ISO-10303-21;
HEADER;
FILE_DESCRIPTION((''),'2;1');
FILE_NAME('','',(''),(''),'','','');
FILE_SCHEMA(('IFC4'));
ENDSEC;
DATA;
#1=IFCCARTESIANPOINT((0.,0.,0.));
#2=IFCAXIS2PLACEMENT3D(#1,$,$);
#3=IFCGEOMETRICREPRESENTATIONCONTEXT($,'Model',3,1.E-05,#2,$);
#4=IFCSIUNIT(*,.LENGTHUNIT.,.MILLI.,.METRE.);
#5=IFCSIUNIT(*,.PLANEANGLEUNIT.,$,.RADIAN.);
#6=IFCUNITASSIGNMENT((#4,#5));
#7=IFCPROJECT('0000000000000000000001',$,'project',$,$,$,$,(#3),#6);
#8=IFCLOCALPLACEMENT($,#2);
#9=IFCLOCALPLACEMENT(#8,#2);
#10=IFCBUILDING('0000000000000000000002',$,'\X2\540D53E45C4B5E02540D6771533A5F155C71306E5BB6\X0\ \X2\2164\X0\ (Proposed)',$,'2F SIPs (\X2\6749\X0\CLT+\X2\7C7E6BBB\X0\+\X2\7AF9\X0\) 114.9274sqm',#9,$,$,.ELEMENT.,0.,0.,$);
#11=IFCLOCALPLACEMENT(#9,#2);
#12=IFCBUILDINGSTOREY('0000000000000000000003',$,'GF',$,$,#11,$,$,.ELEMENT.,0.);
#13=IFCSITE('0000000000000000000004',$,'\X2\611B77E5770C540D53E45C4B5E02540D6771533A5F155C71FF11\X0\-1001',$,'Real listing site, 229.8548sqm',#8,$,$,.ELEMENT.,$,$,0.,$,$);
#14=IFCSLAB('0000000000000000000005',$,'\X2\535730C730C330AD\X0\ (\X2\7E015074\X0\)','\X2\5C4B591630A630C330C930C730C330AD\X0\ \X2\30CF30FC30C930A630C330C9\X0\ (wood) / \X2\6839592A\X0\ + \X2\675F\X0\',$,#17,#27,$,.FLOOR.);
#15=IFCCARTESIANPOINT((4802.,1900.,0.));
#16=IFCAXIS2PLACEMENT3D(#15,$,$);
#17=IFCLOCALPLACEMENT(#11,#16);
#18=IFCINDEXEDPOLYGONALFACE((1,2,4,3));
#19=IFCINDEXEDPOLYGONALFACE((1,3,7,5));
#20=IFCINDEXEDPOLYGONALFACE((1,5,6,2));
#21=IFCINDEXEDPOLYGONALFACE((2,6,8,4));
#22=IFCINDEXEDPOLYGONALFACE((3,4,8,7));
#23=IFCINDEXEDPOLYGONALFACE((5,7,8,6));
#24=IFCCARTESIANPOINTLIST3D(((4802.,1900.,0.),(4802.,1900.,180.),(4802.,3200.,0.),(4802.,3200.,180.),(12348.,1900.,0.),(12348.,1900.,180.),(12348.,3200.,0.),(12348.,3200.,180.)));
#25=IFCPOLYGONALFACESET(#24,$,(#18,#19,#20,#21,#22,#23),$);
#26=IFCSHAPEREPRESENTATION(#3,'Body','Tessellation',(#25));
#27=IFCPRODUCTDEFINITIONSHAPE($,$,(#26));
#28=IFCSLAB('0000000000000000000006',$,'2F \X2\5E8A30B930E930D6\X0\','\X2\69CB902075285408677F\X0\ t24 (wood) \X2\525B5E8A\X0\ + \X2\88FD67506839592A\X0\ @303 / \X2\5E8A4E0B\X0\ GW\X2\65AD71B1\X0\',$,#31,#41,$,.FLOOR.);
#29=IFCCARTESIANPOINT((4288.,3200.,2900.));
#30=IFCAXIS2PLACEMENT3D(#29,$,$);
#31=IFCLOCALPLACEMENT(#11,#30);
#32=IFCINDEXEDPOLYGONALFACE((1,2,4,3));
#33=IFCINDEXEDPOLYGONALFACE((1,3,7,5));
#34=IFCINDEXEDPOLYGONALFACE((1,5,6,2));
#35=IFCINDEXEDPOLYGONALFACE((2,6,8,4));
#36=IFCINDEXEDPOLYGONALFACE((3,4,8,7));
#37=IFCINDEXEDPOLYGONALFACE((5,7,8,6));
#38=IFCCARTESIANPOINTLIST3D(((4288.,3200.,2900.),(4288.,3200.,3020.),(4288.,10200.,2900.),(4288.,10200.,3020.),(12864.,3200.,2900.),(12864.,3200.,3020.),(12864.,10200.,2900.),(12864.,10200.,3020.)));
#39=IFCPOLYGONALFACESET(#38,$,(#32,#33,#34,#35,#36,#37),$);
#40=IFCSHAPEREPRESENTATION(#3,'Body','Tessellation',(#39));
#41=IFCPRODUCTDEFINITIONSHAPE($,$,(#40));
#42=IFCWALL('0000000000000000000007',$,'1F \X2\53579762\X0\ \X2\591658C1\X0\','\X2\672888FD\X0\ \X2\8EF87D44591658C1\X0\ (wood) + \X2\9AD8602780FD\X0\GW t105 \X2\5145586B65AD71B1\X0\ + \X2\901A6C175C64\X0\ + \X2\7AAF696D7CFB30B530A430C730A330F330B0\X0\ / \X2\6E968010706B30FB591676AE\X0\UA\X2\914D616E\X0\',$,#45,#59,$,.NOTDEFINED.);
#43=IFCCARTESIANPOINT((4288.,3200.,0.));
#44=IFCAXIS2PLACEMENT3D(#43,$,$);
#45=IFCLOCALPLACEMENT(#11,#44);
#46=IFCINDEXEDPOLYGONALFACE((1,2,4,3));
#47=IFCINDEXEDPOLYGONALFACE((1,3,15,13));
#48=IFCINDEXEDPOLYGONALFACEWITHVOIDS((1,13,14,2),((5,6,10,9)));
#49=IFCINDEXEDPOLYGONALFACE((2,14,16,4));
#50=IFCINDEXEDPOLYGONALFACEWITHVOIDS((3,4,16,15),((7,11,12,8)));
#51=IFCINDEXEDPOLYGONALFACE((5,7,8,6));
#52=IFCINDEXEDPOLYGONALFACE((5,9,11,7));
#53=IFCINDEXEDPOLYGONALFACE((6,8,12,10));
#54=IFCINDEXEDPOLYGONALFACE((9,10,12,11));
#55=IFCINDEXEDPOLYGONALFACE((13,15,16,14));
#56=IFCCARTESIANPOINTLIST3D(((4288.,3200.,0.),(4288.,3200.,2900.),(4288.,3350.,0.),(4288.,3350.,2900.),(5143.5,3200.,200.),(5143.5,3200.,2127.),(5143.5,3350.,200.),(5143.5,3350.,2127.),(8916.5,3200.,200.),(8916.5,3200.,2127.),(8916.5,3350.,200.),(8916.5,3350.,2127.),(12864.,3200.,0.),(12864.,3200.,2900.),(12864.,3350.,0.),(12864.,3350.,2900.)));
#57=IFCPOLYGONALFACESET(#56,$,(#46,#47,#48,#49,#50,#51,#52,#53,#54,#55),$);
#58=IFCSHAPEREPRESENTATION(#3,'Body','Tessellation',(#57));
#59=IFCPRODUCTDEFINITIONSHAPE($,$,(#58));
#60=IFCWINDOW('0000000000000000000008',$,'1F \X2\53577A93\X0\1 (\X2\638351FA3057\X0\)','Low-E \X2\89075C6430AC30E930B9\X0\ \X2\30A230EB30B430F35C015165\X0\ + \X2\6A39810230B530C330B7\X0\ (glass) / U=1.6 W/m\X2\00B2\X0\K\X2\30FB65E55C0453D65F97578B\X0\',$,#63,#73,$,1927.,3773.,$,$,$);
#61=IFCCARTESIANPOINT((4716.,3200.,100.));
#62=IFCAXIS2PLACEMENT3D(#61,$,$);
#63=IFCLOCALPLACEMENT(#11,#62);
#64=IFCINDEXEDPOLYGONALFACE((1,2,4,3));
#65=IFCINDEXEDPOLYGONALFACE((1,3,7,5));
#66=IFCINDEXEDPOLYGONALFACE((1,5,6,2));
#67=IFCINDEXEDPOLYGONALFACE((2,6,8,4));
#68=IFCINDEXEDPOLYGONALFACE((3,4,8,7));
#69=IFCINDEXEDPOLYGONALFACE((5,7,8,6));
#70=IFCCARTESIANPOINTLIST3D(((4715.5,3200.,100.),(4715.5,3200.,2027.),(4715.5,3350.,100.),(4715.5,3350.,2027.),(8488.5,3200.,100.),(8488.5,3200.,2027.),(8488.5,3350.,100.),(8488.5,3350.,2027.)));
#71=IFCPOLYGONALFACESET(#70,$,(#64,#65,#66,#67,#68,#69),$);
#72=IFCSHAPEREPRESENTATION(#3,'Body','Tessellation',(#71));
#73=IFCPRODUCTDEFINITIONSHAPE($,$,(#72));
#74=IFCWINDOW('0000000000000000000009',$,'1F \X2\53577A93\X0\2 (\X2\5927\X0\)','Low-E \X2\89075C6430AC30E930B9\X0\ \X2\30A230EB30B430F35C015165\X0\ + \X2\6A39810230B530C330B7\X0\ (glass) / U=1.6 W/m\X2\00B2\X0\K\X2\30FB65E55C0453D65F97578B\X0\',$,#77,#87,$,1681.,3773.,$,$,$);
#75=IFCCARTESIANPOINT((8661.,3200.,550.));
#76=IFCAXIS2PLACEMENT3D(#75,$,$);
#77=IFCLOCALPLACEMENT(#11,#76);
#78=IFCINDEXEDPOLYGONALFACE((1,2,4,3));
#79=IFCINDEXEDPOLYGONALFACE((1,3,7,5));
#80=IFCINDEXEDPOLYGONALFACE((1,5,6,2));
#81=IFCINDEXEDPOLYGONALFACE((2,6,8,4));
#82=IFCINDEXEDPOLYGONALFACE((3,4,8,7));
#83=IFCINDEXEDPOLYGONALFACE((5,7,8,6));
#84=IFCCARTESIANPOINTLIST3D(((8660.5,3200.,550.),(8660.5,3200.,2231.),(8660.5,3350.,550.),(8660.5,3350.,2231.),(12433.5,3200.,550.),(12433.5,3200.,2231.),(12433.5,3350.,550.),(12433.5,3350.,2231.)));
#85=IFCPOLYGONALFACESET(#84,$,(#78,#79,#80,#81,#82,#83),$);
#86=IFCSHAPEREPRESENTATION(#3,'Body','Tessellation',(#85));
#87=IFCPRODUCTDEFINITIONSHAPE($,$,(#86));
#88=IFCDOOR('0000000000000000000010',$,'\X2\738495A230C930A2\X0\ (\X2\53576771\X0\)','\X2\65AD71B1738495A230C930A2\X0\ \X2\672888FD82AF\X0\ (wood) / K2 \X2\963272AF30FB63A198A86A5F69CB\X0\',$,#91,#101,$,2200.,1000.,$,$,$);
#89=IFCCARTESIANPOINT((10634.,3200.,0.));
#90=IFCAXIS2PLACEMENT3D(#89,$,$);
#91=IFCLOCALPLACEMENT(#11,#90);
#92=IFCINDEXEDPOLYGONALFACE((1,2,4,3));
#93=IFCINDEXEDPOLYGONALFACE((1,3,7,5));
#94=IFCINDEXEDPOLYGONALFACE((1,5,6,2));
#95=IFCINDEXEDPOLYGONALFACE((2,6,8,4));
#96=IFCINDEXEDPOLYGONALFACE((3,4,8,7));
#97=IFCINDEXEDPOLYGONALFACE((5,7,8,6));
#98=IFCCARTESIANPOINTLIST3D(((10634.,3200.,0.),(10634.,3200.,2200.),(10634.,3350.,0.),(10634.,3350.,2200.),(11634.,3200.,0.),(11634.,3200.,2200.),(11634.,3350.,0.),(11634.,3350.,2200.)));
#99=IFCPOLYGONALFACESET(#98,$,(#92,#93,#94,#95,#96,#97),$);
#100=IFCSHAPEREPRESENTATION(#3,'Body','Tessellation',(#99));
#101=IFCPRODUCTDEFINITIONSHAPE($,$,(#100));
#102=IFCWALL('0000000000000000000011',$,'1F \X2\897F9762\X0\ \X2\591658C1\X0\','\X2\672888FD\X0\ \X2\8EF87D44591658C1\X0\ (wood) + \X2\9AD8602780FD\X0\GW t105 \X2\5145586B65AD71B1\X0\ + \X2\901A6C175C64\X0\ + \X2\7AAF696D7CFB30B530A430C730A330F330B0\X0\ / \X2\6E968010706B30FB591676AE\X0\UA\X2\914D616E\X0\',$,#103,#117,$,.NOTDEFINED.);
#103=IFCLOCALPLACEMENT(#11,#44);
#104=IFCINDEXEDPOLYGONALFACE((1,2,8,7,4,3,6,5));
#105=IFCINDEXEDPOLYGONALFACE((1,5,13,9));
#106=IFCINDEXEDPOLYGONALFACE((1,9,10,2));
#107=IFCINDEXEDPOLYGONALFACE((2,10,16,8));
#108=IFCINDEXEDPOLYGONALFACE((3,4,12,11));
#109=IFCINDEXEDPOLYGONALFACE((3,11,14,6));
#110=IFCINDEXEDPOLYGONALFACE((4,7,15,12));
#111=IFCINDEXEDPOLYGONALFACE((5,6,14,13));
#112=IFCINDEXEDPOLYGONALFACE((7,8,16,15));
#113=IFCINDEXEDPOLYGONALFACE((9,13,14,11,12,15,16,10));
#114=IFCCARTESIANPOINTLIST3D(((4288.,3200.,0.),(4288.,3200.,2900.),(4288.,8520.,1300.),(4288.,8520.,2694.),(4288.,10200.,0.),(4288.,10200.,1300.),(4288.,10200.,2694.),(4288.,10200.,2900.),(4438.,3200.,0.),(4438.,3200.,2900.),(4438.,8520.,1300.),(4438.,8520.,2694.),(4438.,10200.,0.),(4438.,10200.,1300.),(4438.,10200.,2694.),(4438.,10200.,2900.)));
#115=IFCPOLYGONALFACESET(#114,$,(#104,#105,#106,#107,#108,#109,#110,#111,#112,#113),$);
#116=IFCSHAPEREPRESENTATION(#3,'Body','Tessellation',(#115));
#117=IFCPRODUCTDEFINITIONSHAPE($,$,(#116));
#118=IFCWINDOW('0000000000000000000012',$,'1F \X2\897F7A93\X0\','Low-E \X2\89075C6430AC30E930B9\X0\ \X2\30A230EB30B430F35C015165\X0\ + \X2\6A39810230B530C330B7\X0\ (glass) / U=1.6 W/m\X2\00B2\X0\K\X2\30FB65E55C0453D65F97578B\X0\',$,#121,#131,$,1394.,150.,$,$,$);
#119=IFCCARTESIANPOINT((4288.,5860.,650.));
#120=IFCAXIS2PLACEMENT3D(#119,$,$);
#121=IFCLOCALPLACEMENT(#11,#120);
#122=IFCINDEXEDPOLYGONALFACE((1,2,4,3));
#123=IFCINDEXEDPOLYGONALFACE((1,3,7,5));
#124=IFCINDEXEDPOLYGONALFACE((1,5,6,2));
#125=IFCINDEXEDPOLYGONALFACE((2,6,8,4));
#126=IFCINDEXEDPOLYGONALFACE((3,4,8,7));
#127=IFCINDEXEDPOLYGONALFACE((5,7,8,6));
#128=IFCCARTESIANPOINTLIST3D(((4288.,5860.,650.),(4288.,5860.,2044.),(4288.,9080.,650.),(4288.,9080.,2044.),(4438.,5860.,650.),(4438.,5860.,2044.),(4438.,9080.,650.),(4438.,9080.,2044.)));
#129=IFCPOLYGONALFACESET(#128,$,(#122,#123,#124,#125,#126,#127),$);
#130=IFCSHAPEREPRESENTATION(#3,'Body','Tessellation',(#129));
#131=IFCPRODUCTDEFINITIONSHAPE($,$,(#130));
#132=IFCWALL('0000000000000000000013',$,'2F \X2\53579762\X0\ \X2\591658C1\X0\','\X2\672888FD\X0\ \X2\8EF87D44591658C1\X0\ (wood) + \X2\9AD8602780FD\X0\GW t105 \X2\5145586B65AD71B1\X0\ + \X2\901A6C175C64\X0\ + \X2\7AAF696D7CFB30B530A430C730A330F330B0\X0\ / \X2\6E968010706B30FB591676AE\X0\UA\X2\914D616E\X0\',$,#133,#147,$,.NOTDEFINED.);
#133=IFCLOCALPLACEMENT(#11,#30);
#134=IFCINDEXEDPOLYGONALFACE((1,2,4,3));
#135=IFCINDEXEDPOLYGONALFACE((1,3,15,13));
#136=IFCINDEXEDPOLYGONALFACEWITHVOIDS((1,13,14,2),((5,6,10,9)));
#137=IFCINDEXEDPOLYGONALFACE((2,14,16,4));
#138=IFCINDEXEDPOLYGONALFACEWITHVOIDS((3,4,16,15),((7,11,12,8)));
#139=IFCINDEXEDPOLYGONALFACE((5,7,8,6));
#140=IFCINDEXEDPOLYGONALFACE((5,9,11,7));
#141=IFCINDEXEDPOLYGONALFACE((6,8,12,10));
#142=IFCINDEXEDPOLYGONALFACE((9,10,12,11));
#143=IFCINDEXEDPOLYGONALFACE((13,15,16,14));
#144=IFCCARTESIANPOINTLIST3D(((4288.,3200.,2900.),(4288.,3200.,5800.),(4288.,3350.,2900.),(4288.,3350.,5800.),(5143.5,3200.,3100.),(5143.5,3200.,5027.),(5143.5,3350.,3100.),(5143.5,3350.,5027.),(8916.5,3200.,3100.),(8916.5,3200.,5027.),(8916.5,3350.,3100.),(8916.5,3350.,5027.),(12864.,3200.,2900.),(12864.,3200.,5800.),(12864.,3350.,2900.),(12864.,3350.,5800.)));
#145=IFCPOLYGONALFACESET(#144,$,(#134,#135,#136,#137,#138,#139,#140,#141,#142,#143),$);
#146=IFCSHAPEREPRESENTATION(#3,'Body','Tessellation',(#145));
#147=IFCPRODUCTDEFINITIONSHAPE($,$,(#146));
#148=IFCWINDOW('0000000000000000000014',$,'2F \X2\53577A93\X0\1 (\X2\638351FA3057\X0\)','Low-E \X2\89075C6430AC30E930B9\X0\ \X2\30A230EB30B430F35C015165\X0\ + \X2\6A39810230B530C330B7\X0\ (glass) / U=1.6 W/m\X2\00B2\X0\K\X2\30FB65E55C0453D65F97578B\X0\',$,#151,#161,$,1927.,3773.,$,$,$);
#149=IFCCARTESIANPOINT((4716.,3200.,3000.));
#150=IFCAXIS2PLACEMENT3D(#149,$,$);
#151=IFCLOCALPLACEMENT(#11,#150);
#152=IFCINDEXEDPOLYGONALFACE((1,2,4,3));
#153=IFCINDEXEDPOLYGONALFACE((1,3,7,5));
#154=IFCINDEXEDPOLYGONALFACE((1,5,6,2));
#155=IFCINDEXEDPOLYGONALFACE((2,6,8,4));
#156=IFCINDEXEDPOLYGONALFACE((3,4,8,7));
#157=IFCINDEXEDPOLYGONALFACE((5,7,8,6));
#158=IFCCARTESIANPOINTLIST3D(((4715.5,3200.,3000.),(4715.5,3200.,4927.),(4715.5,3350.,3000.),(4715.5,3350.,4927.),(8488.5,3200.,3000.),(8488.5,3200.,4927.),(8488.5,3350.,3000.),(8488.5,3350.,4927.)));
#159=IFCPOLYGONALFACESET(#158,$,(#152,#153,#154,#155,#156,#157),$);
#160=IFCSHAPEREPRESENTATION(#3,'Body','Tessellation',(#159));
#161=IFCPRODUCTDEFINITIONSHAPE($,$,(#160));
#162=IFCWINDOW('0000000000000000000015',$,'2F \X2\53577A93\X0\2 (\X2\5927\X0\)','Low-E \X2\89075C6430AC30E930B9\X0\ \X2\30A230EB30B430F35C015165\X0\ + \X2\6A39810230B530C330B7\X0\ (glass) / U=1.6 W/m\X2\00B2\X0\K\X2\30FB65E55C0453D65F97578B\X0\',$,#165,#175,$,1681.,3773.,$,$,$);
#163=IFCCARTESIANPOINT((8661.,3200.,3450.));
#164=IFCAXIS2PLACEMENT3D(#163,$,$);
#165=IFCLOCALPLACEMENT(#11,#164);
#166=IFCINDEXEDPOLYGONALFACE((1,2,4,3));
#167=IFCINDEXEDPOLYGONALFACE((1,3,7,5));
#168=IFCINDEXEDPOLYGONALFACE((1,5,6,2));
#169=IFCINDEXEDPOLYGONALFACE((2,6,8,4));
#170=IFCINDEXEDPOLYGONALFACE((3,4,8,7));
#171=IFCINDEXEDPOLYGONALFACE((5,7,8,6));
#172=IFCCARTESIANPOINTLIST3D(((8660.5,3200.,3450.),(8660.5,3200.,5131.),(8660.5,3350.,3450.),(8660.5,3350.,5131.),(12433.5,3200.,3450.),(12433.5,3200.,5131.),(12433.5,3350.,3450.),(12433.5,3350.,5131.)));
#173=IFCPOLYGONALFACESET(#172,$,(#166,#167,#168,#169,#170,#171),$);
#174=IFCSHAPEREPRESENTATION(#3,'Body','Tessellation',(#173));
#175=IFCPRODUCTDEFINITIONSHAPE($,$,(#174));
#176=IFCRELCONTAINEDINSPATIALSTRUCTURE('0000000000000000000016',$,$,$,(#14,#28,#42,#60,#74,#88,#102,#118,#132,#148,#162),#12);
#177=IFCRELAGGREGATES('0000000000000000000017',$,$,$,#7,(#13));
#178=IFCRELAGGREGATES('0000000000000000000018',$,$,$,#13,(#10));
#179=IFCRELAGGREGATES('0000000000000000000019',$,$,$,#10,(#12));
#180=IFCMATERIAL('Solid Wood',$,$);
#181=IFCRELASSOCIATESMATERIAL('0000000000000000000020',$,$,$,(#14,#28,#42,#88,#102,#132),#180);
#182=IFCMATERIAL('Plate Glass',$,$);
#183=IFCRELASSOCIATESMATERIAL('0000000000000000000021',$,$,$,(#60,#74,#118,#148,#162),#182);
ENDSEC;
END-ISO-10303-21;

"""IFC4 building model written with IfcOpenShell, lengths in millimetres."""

from ifc_helpers import new_model, si_unit, frame, frame_2d, origin, place, context, project, spatial, rectangle, extrude, material, element, fill, save


model = new_model("IFC4")

# Units and contexts
model_context = context("Model", 3, precision=1e-05, world=origin())
ifc_project = project(units=[si_unit("LENGTHUNIT", "METRE", prefix="MILLI"), si_unit("PLANEANGLEUNIT", "RADIAN")], contexts=[model_context])

# Site, building, storey
site_placement = place(None, origin())
site = spatial("IfcSite", under=ifc_project, at=site_placement, Name="愛知県名古屋市名東区引山１-1001", ObjectType="Real listing site, 229.8548sqm", CompositionType="ELEMENT", RefElevation=0.0)
building_placement = place(site_placement, origin())
building = spatial("IfcBuilding", under=site, at=building_placement, Name="名古屋市名東区引山の家 Ⅴ (Proposed)", ObjectType="2F SIPs (杉CLT+籾殻+竹) 114.9274sqm", CompositionType="ELEMENT", ElevationOfRefHeight=0.0, ElevationOfTerrain=0.0)
storey_placement = place(building_placement, origin())
storey = spatial("IfcBuildingStorey", under=building, at=storey_placement, Name="GF", CompositionType="ELEMENT", Elevation=0.0)

# Slabs
ifc_material_1 = material(Name="Solid Wood")
slab_1_placement = place(storey_placement, frame((4802.0, 1900.0, 0.0)))
element("IfcSlab", 1, at=slab_1_placement, inside=storey, material=ifc_material_1, Name="南デッキ (縁側)", Description="屋外ウッドデッキ ハードウッド (wood) / 根太 + 束", PredefinedType="FLOOR", context=model_context, shape_type="SweptSolid", body=[
    extrude(rectangle(XDim=7546.0, YDim=1300.0, at=frame_2d((3773.0, 650.0))), frame((4802.0, 1900.0, 0.0)), (0.0, 0.0, 1.0), 180.0),
])
slab_2_placement = place(storey_placement, frame((4288.0, 3200.0, 2900.0)))
element("IfcSlab", 2, at=slab_2_placement, inside=storey, material=ifc_material_1, Name="2F 床スラブ", Description="構造用合板 t24 (wood) 剛床 + 製材根太 @303 / 床下 GW断熱", PredefinedType="FLOOR", context=model_context, shape_type="SweptSolid", body=[
    extrude(rectangle(XDim=8576.0, YDim=7000.0, at=frame_2d((4288.0, 3500.0))), frame((4288.0, 3200.0, 2900.0)), (0.0, 0.0, 1.0), 120.0),
])

# Wall, openings, windows, door
wall_1_placement = place(storey_placement, frame((4288.0, 3200.0, 0.0)))
wall_1 = element("IfcWall", 3, at=wall_1_placement, inside=storey, material=ifc_material_1, Name="1F 南面 外壁", Description="木製 軸組外壁 (wood) + 高性能GW t105 充填断熱 + 通気層 + 窯業系サイディング / 準耐火・外皮UA配慮", PredefinedType="NOTDEFINED", context=model_context, shape_type="SweptSolid", body=[
    extrude(rectangle(XDim=8576.0, YDim=150.0, at=frame_2d((4288.0, 75.0))), frame((4288.0, 3200.0, 0.0)), (0.0, 0.0, 1.0), 2900.0),
])
opening_1_placement = place(storey_placement, frame((4716.0, 3200.0, 100.0)))
opening_1 = element("IfcOpeningElement", 4, at=opening_1_placement, cuts=wall_1, PredefinedType="NOTDEFINED", context=model_context, shape_type="SweptSolid", body=[
    extrude(rectangle(XDim=3773.0, YDim=150.0, at=frame_2d((1886.0, 75.0))), frame((4716.0, 3200.0, 100.0)), (0.0, 0.0, 1.0), 1927.0),
])
opening_2_placement = place(storey_placement, frame((8661.0, 3200.0, 550.0)))
opening_2 = element("IfcOpeningElement", 5, at=opening_2_placement, cuts=wall_1, PredefinedType="NOTDEFINED", context=model_context, shape_type="SweptSolid", body=[
    extrude(rectangle(XDim=3773.0, YDim=150.0, at=frame_2d((1886.0, 75.0))), frame((8661.0, 3200.0, 550.0)), (0.0, 0.0, 1.0), 1681.0),
])
opening_3_placement = place(storey_placement, frame((10634.0, 3200.0, 0.0)))
opening_3 = element("IfcOpeningElement", 6, at=opening_3_placement, cuts=wall_1, PredefinedType="NOTDEFINED", context=model_context, shape_type="SweptSolid", body=[
    extrude(rectangle(XDim=1000.0, YDim=150.0, at=frame_2d((500.0, 75.0))), frame((10634.0, 3200.0, 0.0)), (0.0, 0.0, 1.0), 2200.0),
])
ifc_material_2 = material(Name="Plate Glass")
window_1_placement = place(storey_placement, frame((4716.0, 3200.0, 100.0)))
window_1 = element("IfcWindow", 7, at=window_1_placement, inside=storey, material=ifc_material_2, Name="1F 南窓1 (掃出し)", Description="Low-E 複層ガラス アルゴン封入 + 樹脂サッシ (glass) / U=1.6 W/m²K・日射取得型", OverallHeight=1927.0, OverallWidth=3773.0, context=model_context, shape_type="SweptSolid", body=[
    extrude(rectangle(XDim=3773.0, YDim=150.0, at=frame_2d((1886.0, 75.0))), frame((4716.0, 3200.0, 100.0)), (0.0, 0.0, 1.0), 1927.0),
])
fill(opening_1, window_1)
window_2_placement = place(storey_placement, frame((8661.0, 3200.0, 550.0)))
window_2 = element("IfcWindow", 8, at=window_2_placement, inside=storey, material=ifc_material_2, Name="1F 南窓2 (大)", Description="Low-E 複層ガラス アルゴン封入 + 樹脂サッシ (glass) / U=1.6 W/m²K・日射取得型", OverallHeight=1681.0, OverallWidth=3773.0, context=model_context, shape_type="SweptSolid", body=[
    extrude(rectangle(XDim=3773.0, YDim=150.0, at=frame_2d((1886.0, 75.0))), frame((8661.0, 3200.0, 550.0)), (0.0, 0.0, 1.0), 1681.0),
])
fill(opening_2, window_2)
door_placement = place(storey_placement, frame((10634.0, 3200.0, 0.0)))
door = element("IfcDoor", 9, at=door_placement, inside=storey, material=ifc_material_1, Name="玄関ドア (南東)", Description="断熱玄関ドア 木製芯 (wood) / K2 防犯・採風機構", OverallHeight=2200.0, OverallWidth=1000.0, context=model_context, shape_type="SweptSolid", body=[
    extrude(rectangle(XDim=1000.0, YDim=150.0, at=frame_2d((500.0, 75.0))), frame((10634.0, 3200.0, 0.0)), (0.0, 0.0, 1.0), 2200.0),
])
fill(opening_3, door)

# Wall, opening, window
wall_2_placement = place(storey_placement, frame((4288.0, 3200.0, 0.0)))
wall_2 = element("IfcWall", 10, at=wall_2_placement, inside=storey, material=ifc_material_1, Name="1F 西面 外壁", Description="木製 軸組外壁 (wood) + 高性能GW t105 充填断熱 + 通気層 + 窯業系サイディング / 準耐火・外皮UA配慮", PredefinedType="NOTDEFINED", context=model_context, shape_type="SweptSolid", body=[
    extrude(rectangle(XDim=150.0, YDim=7000.0, at=frame_2d((75.0, 3500.0))), frame((4288.0, 3200.0, 0.0)), (0.0, 0.0, 1.0), 2900.0),
])
opening_4_placement = place(storey_placement, frame((4288.0, 5860.0, 650.0)))
opening_4 = element("IfcOpeningElement", 11, at=opening_4_placement, cuts=wall_2, PredefinedType="NOTDEFINED", context=model_context, shape_type="SweptSolid", body=[
    extrude(rectangle(XDim=150.0, YDim=3220.0, at=frame_2d((75.0, 1610.0))), frame((4288.0, 5860.0, 650.0)), (0.0, 0.0, 1.0), 1394.0),
])
window_3_placement = place(storey_placement, frame((4288.0, 5860.0, 650.0)))
window_3 = element("IfcWindow", 12, at=window_3_placement, inside=storey, material=ifc_material_2, Name="1F 西窓", Description="Low-E 複層ガラス アルゴン封入 + 樹脂サッシ (glass) / U=1.6 W/m²K・日射取得型", OverallHeight=1394.0, OverallWidth=150.0, context=model_context, shape_type="SweptSolid", body=[
    extrude(rectangle(XDim=150.0, YDim=3220.0, at=frame_2d((75.0, 1610.0))), frame((4288.0, 5860.0, 650.0)), (0.0, 0.0, 1.0), 1394.0),
])
fill(opening_4, window_3)

# Wall, openings, windows
wall_3_placement = place(storey_placement, frame((4288.0, 3200.0, 2900.0)))
wall_3 = element("IfcWall", 13, at=wall_3_placement, inside=storey, material=ifc_material_1, Name="2F 南面 外壁", Description="木製 軸組外壁 (wood) + 高性能GW t105 充填断熱 + 通気層 + 窯業系サイディング / 準耐火・外皮UA配慮", PredefinedType="NOTDEFINED", context=model_context, shape_type="SweptSolid", body=[
    extrude(rectangle(XDim=8576.0, YDim=150.0, at=frame_2d((4288.0, 75.0))), frame((4288.0, 3200.0, 2900.0)), (0.0, 0.0, 1.0), 2900.0),
])
opening_5_placement = place(storey_placement, frame((4716.0, 3200.0, 3000.0)))
opening_5 = element("IfcOpeningElement", 14, at=opening_5_placement, cuts=wall_3, PredefinedType="NOTDEFINED", context=model_context, shape_type="SweptSolid", body=[
    extrude(rectangle(XDim=3773.0, YDim=150.0, at=frame_2d((1886.0, 75.0))), frame((4716.0, 3200.0, 3000.0)), (0.0, 0.0, 1.0), 1927.0),
])
opening_6_placement = place(storey_placement, frame((8661.0, 3200.0, 3450.0)))
opening_6 = element("IfcOpeningElement", 15, at=opening_6_placement, cuts=wall_3, PredefinedType="NOTDEFINED", context=model_context, shape_type="SweptSolid", body=[
    extrude(rectangle(XDim=3773.0, YDim=150.0, at=frame_2d((1886.0, 75.0))), frame((8661.0, 3200.0, 3450.0)), (0.0, 0.0, 1.0), 1681.0),
])
window_4_placement = place(storey_placement, frame((4716.0, 3200.0, 3000.0)))
window_4 = element("IfcWindow", 16, at=window_4_placement, inside=storey, material=ifc_material_2, Name="2F 南窓1 (掃出し)", Description="Low-E 複層ガラス アルゴン封入 + 樹脂サッシ (glass) / U=1.6 W/m²K・日射取得型", OverallHeight=1927.0, OverallWidth=3773.0, context=model_context, shape_type="SweptSolid", body=[
    extrude(rectangle(XDim=3773.0, YDim=150.0, at=frame_2d((1886.0, 75.0))), frame((4716.0, 3200.0, 3000.0)), (0.0, 0.0, 1.0), 1927.0),
])
fill(opening_5, window_4)
window_5_placement = place(storey_placement, frame((8661.0, 3200.0, 3450.0)))
window_5 = element("IfcWindow", 17, at=window_5_placement, inside=storey, material=ifc_material_2, Name="2F 南窓2 (大)", Description="Low-E 複層ガラス アルゴン封入 + 樹脂サッシ (glass) / U=1.6 W/m²K・日射取得型", OverallHeight=1681.0, OverallWidth=3773.0, context=model_context, shape_type="SweptSolid", body=[
    extrude(rectangle(XDim=3773.0, YDim=150.0, at=frame_2d((1886.0, 75.0))), frame((8661.0, 3200.0, 3450.0)), (0.0, 0.0, 1.0), 1681.0),
])
fill(opening_6, window_5)

save(model, "model.ifc")
